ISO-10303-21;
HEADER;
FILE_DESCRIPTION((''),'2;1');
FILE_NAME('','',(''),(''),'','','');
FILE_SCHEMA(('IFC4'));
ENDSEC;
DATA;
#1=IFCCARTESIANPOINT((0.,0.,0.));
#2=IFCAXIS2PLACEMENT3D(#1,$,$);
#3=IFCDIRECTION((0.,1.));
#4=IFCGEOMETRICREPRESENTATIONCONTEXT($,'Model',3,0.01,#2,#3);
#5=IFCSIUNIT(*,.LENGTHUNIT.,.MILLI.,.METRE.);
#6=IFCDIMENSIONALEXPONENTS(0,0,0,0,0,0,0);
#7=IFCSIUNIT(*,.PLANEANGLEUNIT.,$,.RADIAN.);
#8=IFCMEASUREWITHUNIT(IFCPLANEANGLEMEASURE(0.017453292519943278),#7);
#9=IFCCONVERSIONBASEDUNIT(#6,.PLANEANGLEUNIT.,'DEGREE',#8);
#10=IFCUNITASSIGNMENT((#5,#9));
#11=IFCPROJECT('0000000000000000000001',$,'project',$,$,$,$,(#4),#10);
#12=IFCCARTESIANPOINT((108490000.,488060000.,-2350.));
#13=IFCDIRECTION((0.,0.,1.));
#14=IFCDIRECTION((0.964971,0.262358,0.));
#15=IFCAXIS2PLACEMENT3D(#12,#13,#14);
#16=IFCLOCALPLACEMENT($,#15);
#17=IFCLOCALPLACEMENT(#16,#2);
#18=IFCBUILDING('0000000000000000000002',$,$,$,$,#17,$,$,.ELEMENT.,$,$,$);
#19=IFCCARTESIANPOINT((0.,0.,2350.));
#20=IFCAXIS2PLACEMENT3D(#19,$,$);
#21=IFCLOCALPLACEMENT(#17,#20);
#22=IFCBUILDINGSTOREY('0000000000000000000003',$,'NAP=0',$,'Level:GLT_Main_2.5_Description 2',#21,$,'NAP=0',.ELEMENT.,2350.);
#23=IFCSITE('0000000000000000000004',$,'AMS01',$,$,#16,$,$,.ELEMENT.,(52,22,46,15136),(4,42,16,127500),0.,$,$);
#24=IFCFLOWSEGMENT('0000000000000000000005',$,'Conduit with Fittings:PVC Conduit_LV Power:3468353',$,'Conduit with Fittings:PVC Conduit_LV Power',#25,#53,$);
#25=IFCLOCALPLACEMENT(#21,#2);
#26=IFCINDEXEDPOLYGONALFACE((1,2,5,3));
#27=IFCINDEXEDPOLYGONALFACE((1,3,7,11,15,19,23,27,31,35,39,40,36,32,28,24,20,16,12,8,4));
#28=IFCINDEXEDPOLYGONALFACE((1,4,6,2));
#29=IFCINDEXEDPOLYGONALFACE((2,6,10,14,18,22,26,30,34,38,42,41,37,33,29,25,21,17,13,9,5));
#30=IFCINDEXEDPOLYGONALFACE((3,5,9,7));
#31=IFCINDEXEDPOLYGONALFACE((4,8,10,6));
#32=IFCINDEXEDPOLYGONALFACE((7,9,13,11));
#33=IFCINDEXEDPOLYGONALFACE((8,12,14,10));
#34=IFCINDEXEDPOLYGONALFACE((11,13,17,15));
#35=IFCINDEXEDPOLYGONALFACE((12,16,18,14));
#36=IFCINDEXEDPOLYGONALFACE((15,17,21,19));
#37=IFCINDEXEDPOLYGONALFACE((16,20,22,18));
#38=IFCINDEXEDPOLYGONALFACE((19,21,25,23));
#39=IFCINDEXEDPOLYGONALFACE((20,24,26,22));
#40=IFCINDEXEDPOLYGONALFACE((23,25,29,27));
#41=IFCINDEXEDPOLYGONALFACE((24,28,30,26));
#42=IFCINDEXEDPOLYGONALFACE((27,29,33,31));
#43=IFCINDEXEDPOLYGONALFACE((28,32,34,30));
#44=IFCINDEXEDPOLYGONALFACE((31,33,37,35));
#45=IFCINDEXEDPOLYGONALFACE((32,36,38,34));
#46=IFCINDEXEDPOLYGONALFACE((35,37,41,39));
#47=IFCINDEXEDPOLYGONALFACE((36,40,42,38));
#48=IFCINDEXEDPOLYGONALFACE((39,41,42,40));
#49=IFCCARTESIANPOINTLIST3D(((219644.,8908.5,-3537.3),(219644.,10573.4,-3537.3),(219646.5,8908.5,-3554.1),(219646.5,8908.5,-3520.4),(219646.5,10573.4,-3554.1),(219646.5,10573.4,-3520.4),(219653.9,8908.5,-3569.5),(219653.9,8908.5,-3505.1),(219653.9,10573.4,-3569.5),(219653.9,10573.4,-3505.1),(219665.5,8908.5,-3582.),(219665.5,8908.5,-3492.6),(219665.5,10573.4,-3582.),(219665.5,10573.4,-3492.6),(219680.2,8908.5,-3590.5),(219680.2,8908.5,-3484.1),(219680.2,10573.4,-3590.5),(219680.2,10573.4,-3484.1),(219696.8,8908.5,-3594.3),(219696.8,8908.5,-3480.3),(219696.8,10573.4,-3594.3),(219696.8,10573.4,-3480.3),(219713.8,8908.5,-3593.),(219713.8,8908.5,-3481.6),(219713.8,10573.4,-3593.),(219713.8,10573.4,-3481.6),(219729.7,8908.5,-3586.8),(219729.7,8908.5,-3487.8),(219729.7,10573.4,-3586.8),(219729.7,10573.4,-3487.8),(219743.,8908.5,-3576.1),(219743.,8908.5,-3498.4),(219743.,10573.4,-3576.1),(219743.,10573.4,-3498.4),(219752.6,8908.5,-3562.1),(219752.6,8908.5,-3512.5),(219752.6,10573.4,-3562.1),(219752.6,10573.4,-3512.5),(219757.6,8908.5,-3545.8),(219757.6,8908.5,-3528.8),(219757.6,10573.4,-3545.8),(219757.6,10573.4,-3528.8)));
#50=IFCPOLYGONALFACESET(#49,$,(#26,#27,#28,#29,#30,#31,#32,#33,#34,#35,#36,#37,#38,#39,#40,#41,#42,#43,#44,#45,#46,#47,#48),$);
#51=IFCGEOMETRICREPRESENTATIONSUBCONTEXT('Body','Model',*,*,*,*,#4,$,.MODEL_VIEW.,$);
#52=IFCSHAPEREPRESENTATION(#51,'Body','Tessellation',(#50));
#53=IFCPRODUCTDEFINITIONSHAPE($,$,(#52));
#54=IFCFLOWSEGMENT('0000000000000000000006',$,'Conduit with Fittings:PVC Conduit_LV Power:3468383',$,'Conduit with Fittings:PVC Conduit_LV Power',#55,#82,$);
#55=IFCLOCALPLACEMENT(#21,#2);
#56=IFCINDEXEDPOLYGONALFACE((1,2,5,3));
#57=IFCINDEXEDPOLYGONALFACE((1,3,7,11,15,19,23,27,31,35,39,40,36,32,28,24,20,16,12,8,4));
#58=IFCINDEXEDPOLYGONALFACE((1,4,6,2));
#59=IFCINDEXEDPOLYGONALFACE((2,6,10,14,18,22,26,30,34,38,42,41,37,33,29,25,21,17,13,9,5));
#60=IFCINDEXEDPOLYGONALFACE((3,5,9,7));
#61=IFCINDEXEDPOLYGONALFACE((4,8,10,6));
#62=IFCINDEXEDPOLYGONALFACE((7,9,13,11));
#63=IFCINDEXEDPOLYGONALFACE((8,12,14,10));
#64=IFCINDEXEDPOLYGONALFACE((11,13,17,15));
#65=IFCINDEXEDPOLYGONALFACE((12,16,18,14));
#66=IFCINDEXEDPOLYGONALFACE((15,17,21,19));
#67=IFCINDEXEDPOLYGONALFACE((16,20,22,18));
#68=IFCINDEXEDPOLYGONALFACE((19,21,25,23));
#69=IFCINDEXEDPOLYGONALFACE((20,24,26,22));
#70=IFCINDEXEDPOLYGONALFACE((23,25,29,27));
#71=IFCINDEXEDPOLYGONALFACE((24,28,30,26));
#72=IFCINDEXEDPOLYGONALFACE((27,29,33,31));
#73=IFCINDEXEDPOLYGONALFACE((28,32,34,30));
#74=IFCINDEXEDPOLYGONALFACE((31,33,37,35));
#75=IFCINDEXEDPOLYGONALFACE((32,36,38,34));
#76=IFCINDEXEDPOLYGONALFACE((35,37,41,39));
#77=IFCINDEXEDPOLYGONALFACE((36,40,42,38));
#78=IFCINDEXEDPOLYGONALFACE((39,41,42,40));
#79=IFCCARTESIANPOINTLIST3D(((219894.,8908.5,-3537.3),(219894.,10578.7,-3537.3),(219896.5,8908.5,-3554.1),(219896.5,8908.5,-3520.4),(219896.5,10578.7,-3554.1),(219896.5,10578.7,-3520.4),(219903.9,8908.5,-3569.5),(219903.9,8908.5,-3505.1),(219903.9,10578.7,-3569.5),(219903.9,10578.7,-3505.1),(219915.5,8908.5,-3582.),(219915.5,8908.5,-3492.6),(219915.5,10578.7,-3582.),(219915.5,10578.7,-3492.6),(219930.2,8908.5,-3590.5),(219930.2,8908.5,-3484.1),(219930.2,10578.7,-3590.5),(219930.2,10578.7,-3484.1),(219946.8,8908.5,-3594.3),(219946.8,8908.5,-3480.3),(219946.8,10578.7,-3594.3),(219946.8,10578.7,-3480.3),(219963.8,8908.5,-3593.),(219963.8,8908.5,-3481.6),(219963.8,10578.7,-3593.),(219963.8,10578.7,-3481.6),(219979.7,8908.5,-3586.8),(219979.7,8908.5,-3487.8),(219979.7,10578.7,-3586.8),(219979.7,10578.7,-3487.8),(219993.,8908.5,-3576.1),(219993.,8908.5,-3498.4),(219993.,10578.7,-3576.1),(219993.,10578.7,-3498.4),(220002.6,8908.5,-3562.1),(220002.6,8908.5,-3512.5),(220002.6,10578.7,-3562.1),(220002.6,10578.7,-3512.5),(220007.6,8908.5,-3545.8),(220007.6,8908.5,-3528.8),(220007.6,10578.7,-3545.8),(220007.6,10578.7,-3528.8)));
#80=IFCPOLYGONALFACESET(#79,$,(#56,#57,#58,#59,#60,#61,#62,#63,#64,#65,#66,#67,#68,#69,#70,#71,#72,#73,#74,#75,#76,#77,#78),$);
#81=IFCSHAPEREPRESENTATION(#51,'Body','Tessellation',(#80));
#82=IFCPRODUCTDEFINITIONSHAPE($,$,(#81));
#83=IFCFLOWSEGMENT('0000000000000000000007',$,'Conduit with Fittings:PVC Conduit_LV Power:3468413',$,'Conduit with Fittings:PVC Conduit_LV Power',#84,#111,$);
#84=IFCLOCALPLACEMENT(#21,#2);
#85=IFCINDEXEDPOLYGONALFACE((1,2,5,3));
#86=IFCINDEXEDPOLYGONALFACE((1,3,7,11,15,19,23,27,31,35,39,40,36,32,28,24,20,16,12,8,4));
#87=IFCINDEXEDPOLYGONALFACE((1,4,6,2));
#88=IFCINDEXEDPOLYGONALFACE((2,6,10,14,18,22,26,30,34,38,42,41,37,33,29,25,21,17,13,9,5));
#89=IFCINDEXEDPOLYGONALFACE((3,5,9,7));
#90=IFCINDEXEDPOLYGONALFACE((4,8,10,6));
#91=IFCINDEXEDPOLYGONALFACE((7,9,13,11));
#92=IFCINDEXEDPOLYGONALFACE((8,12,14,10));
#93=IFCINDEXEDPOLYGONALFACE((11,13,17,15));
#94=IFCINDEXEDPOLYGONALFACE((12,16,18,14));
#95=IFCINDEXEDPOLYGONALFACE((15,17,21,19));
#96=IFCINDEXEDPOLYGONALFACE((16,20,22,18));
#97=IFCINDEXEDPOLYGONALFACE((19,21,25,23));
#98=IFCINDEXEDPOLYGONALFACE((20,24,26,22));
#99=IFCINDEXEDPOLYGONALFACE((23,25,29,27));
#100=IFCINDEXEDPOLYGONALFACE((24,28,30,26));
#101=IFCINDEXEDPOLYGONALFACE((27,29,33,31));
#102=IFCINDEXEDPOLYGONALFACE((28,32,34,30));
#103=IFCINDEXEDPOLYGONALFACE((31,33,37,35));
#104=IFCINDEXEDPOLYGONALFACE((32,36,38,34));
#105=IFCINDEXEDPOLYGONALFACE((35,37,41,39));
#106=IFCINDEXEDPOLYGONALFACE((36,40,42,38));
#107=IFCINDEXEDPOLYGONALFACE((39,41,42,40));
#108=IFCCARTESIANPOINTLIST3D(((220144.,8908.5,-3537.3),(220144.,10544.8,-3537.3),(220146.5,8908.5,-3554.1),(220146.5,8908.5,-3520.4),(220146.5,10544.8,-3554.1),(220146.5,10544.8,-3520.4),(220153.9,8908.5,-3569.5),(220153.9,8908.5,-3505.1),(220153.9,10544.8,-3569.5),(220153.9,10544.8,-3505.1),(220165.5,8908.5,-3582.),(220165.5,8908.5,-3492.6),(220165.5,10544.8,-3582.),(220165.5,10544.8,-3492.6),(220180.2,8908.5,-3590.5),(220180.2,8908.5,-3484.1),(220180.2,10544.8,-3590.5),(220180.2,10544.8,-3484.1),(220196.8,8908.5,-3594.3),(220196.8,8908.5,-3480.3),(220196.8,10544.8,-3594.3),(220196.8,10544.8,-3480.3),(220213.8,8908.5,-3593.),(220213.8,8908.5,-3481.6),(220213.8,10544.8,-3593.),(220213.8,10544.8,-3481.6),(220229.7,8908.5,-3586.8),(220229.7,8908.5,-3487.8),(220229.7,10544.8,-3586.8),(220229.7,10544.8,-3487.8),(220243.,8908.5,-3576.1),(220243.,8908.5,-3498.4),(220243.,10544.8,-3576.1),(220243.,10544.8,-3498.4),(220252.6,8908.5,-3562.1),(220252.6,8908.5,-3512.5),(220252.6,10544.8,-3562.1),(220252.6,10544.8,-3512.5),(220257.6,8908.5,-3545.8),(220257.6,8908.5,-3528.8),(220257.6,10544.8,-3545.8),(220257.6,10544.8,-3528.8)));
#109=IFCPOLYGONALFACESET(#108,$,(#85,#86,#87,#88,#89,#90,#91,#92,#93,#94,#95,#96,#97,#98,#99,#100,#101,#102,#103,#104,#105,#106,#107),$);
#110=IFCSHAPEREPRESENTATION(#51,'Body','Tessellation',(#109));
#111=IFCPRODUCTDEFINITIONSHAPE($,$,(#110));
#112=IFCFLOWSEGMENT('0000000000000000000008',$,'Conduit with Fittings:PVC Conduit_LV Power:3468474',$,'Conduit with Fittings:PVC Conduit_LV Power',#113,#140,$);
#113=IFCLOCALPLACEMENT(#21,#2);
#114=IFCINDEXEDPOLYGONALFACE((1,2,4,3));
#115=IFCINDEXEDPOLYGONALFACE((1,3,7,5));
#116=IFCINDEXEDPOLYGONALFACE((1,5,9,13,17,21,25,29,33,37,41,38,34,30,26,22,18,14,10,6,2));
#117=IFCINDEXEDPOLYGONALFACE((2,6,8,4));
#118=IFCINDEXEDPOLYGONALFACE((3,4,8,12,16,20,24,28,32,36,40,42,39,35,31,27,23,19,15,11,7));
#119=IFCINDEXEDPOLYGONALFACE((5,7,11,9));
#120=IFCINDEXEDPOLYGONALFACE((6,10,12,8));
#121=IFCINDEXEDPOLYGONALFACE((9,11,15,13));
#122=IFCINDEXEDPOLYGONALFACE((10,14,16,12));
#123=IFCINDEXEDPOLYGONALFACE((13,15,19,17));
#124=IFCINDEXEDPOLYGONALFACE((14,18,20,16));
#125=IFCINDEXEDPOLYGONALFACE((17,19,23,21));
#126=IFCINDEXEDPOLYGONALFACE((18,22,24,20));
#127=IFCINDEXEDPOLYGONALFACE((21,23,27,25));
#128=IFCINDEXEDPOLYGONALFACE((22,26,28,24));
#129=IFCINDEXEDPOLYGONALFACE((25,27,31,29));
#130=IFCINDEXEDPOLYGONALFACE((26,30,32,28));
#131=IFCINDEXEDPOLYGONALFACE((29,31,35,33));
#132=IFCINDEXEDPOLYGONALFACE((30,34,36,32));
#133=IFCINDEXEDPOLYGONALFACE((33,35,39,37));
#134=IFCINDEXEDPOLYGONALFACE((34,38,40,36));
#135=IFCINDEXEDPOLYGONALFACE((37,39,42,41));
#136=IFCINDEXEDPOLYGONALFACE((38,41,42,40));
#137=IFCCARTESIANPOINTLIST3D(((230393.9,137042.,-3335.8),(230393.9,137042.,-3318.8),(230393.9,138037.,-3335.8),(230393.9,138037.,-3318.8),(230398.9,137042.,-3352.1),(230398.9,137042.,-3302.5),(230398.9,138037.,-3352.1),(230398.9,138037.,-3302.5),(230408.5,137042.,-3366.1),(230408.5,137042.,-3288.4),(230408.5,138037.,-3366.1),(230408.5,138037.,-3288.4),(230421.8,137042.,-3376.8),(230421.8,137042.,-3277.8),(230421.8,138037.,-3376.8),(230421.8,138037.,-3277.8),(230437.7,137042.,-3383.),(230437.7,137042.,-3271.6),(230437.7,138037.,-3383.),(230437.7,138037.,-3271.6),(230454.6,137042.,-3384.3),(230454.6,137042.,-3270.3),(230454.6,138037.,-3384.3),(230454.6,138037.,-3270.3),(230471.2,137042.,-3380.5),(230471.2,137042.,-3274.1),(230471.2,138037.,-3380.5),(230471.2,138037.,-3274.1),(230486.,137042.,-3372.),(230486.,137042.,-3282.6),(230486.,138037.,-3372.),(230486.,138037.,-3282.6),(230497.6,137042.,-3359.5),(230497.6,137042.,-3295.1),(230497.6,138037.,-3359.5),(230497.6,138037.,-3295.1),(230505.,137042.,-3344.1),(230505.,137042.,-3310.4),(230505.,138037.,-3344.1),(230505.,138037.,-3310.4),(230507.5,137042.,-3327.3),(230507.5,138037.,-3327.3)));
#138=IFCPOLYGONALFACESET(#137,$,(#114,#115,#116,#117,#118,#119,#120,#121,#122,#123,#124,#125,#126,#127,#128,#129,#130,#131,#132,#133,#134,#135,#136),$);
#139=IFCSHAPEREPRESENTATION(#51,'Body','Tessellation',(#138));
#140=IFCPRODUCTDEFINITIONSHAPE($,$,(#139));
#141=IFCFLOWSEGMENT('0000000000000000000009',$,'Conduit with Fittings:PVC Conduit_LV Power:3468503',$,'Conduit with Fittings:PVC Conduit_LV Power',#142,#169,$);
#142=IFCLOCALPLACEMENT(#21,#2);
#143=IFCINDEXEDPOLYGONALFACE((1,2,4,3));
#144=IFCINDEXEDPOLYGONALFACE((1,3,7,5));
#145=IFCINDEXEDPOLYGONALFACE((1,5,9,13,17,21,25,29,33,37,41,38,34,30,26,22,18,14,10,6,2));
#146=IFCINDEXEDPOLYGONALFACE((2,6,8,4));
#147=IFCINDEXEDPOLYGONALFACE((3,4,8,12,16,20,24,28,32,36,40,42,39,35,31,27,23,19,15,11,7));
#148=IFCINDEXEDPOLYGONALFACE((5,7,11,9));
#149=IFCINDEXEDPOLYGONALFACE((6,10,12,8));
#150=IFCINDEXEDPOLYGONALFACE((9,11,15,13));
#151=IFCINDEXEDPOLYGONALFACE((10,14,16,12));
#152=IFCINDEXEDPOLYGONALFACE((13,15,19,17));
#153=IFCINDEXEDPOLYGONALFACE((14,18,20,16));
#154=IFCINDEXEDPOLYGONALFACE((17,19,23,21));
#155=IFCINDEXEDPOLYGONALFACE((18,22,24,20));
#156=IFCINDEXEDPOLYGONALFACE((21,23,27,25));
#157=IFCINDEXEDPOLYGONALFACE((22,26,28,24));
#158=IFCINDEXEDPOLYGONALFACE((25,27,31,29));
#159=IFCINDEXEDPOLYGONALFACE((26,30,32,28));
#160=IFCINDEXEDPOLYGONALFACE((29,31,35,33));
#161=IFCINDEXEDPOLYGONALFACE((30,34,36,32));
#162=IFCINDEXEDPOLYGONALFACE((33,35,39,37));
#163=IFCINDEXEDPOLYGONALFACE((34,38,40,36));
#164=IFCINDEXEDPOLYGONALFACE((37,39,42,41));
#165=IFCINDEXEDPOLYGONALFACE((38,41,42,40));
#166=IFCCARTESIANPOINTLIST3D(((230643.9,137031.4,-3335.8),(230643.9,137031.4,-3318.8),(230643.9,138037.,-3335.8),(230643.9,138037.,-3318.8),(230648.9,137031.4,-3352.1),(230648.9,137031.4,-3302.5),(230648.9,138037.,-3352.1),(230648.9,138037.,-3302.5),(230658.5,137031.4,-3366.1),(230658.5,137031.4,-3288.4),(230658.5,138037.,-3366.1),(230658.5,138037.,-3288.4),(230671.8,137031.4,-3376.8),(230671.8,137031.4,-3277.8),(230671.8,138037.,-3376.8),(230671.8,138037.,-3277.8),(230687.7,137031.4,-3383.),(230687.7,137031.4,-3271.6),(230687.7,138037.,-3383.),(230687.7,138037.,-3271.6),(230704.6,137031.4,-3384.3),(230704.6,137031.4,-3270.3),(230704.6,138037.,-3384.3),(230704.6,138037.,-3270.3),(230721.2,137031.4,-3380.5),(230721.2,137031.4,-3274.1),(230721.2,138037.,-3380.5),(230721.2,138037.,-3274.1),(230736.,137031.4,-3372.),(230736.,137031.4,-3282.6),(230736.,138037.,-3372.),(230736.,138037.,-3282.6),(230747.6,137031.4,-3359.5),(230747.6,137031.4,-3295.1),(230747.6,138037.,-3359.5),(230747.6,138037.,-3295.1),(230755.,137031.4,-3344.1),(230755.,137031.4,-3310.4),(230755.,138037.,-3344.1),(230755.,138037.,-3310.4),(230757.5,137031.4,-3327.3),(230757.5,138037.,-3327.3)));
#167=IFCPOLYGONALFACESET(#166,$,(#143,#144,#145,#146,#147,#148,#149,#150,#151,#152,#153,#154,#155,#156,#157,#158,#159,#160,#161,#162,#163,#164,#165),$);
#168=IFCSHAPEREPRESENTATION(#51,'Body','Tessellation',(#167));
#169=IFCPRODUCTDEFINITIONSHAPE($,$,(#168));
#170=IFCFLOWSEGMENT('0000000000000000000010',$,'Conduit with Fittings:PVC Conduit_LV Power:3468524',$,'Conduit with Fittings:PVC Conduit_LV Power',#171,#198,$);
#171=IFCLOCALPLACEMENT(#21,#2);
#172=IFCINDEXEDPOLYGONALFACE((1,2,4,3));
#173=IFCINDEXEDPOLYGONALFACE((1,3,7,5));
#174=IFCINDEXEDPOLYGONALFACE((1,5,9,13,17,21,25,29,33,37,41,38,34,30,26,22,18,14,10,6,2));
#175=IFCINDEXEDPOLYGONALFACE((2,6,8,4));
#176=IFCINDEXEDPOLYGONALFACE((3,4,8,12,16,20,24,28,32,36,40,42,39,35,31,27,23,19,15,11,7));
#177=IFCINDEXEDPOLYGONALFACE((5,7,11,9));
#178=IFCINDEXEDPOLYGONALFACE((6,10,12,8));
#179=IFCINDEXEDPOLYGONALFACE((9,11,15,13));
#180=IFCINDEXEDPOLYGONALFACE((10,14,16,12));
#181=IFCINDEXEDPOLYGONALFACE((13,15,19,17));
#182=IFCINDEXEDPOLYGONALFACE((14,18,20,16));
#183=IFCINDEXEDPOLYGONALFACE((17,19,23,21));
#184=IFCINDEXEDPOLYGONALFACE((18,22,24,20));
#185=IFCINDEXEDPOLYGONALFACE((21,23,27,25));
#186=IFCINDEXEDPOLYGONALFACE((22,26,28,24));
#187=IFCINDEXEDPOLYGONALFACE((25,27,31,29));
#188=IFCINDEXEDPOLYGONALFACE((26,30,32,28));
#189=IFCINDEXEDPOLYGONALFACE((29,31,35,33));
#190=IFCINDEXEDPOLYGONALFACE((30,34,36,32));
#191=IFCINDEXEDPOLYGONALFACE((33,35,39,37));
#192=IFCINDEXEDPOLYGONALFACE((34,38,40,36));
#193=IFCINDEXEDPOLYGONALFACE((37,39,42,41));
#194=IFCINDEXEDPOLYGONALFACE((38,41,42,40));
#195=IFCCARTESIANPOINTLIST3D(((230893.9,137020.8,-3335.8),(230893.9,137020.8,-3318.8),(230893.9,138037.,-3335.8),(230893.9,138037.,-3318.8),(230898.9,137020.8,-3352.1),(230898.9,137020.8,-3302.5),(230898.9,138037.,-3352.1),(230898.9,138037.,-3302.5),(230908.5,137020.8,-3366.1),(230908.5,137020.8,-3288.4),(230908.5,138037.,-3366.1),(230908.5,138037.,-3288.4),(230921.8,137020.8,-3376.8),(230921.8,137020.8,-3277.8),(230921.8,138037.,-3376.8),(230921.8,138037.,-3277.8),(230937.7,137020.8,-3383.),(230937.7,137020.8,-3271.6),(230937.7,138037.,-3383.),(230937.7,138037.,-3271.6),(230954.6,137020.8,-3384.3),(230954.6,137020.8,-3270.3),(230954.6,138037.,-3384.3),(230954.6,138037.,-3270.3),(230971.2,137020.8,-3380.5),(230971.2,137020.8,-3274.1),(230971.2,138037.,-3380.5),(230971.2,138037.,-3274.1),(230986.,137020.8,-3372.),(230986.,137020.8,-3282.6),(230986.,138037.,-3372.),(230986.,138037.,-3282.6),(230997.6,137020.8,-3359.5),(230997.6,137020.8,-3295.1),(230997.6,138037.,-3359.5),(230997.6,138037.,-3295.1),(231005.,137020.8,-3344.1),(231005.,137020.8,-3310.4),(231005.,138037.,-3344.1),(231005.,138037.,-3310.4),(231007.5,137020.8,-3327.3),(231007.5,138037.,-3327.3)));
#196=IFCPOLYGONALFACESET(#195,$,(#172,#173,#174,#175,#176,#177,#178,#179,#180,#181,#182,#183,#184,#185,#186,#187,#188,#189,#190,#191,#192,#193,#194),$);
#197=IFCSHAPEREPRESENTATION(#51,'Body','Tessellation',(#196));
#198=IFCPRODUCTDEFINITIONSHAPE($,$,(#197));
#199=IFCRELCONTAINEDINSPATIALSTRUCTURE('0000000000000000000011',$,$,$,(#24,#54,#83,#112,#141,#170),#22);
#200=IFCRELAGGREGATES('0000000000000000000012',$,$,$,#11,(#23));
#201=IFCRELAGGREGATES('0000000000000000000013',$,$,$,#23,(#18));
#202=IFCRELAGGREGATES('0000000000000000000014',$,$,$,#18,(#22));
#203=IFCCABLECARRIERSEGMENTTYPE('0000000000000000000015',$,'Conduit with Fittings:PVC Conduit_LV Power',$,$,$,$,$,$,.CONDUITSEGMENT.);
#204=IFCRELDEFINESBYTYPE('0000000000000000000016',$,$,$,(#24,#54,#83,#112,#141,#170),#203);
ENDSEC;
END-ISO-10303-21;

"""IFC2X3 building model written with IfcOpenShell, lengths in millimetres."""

from ifc_helpers import new_model, entity, si_unit, converted_unit, direction, frame, frame_2d, origin, place, context, subcontext, project, spatial, circle, extrude, type_object, element, save


model = new_model("IFC2X3")

# Units and contexts
model_context = context("Model", 3, precision=0.01, world=origin(), true_north=direction((0.0, 1.0)))
body_context = subcontext(model_context, "Body", "Model", "MODEL_VIEW")
ifc_project = project(units=[si_unit("LENGTHUNIT", "METRE", prefix="MILLI"), converted_unit("PLANEANGLEUNIT", "DEGREE", entity("IfcPlaneAngleMeasure", 0.017453292519943278), si_unit("PLANEANGLEUNIT", "RADIAN"), dimensions=[0, 0, 0, 0, 0, 0, 0])], contexts=[model_context])

# Site, building, storey
site_placement = place(None, frame((108490000.0, 488060000.0, -2350.0), z_axis=(0.0, 0.0, 1.0), x_axis=(0.964971, 0.262358, 0.0)))
site = spatial("IfcSite", under=ifc_project, at=site_placement, Name="AMS01", CompositionType="ELEMENT", RefLatitude=(52, 22, 46, 15136), RefLongitude=(4, 42, 16, 127500), RefElevation=0.0)
building_placement = place(site_placement, origin())
building = spatial("IfcBuilding", under=site, at=building_placement, CompositionType="ELEMENT")
storey_placement = place(building_placement, frame((0.0, 0.0, 2350.0)))
storey = spatial("IfcBuildingStorey", under=building, at=storey_placement, Name="NAP=0", ObjectType="Level:GLT_Main_2.5_Description 2", LongName="NAP=0", CompositionType="ELEMENT", Elevation=2350.0)

# Flow segments
cable_carrier_segment_type = type_object("IfcCableCarrierSegmentType", Name="Conduit with Fittings:PVC Conduit_LV Power", PredefinedType="CONDUITSEGMENT")
flow_segment_1_placement = place(storey_placement, origin())
element("IfcFlowSegment", 1, at=flow_segment_1_placement, inside=storey, type_object=cable_carrier_segment_type, Name="Conduit with Fittings:PVC Conduit_LV Power:3468353", ObjectType="Conduit with Fittings:PVC Conduit_LV Power", context=body_context, shape_type="SweptSolid", body=[
    extrude(circle(Radius=57.2, at=frame_2d((0.0, 0.0), x_axis=(1.0, 0.0))), frame((219701.1, 8908.5, -3537.3), z_axis=(0.0, 1.0, 0.0), x_axis=(-1.0, 0.0, 0.0)), (0.0, 0.0, 1.0), 1665.0),
])
flow_segment_2_placement = place(storey_placement, origin())
element("IfcFlowSegment", 2, at=flow_segment_2_placement, inside=storey, type_object=cable_carrier_segment_type, Name="Conduit with Fittings:PVC Conduit_LV Power:3468383", ObjectType="Conduit with Fittings:PVC Conduit_LV Power", context=body_context, shape_type="SweptSolid", body=[
    extrude(circle(Radius=57.2, at=frame_2d((0.0, 0.0), x_axis=(1.0, 0.0))), frame((219951.1, 8908.5, -3537.3), z_axis=(0.0, 1.0, 0.0), x_axis=(-1.0, 0.0, 0.0)), (0.0, 0.0, 1.0), 1670.3),
])
flow_segment_3_placement = place(storey_placement, origin())
element("IfcFlowSegment", 3, at=flow_segment_3_placement, inside=storey, type_object=cable_carrier_segment_type, Name="Conduit with Fittings:PVC Conduit_LV Power:3468413", ObjectType="Conduit with Fittings:PVC Conduit_LV Power", context=body_context, shape_type="SweptSolid", body=[
    extrude(circle(Radius=57.2, at=frame_2d((0.0, 0.0), x_axis=(1.0, 0.0))), frame((220201.1, 8908.5, -3537.3), z_axis=(0.0, 1.0, 0.0), x_axis=(-1.0, 0.0, 0.0)), (0.0, 0.0, 1.0), 1636.3),
])
flow_segment_4_placement = place(storey_placement, origin())
element("IfcFlowSegment", 4, at=flow_segment_4_placement, inside=storey, type_object=cable_carrier_segment_type, Name="Conduit with Fittings:PVC Conduit_LV Power:3468474", ObjectType="Conduit with Fittings:PVC Conduit_LV Power", context=body_context, shape_type="SweptSolid", body=[
    extrude(circle(Radius=57.2, at=frame_2d((0.0, 0.0), x_axis=(1.0, 0.0))), frame((230450.4, 137042.0, -3327.3), z_axis=(0.0, 1.0, 0.0), x_axis=(1.0, 0.0, 0.0)), (0.0, 0.0, 1.0), 995.0),
])
flow_segment_5_placement = place(storey_placement, origin())
element("IfcFlowSegment", 5, at=flow_segment_5_placement, inside=storey, type_object=cable_carrier_segment_type, Name="Conduit with Fittings:PVC Conduit_LV Power:3468503", ObjectType="Conduit with Fittings:PVC Conduit_LV Power", context=body_context, shape_type="SweptSolid", body=[
    extrude(circle(Radius=57.2, at=frame_2d((0.0, 0.0), x_axis=(1.0, 0.0))), frame((230700.4, 137031.4, -3327.3), z_axis=(0.0, 1.0, 0.0), x_axis=(1.0, 0.0, 0.0)), (0.0, 0.0, 1.0), 1005.6),
])
flow_segment_6_placement = place(storey_placement, origin())
element("IfcFlowSegment", 6, at=flow_segment_6_placement, inside=storey, type_object=cable_carrier_segment_type, Name="Conduit with Fittings:PVC Conduit_LV Power:3468524", ObjectType="Conduit with Fittings:PVC Conduit_LV Power", context=body_context, shape_type="SweptSolid", body=[
    extrude(circle(Radius=57.2, at=frame_2d((0.0, 0.0), x_axis=(1.0, 0.0))), frame((230950.4, 137020.8, -3327.3), z_axis=(0.0, 1.0, 0.0), x_axis=(1.0, 0.0, 0.0)), (0.0, 0.0, 1.0), 1016.2),
])

save(model, "model.ifc")
